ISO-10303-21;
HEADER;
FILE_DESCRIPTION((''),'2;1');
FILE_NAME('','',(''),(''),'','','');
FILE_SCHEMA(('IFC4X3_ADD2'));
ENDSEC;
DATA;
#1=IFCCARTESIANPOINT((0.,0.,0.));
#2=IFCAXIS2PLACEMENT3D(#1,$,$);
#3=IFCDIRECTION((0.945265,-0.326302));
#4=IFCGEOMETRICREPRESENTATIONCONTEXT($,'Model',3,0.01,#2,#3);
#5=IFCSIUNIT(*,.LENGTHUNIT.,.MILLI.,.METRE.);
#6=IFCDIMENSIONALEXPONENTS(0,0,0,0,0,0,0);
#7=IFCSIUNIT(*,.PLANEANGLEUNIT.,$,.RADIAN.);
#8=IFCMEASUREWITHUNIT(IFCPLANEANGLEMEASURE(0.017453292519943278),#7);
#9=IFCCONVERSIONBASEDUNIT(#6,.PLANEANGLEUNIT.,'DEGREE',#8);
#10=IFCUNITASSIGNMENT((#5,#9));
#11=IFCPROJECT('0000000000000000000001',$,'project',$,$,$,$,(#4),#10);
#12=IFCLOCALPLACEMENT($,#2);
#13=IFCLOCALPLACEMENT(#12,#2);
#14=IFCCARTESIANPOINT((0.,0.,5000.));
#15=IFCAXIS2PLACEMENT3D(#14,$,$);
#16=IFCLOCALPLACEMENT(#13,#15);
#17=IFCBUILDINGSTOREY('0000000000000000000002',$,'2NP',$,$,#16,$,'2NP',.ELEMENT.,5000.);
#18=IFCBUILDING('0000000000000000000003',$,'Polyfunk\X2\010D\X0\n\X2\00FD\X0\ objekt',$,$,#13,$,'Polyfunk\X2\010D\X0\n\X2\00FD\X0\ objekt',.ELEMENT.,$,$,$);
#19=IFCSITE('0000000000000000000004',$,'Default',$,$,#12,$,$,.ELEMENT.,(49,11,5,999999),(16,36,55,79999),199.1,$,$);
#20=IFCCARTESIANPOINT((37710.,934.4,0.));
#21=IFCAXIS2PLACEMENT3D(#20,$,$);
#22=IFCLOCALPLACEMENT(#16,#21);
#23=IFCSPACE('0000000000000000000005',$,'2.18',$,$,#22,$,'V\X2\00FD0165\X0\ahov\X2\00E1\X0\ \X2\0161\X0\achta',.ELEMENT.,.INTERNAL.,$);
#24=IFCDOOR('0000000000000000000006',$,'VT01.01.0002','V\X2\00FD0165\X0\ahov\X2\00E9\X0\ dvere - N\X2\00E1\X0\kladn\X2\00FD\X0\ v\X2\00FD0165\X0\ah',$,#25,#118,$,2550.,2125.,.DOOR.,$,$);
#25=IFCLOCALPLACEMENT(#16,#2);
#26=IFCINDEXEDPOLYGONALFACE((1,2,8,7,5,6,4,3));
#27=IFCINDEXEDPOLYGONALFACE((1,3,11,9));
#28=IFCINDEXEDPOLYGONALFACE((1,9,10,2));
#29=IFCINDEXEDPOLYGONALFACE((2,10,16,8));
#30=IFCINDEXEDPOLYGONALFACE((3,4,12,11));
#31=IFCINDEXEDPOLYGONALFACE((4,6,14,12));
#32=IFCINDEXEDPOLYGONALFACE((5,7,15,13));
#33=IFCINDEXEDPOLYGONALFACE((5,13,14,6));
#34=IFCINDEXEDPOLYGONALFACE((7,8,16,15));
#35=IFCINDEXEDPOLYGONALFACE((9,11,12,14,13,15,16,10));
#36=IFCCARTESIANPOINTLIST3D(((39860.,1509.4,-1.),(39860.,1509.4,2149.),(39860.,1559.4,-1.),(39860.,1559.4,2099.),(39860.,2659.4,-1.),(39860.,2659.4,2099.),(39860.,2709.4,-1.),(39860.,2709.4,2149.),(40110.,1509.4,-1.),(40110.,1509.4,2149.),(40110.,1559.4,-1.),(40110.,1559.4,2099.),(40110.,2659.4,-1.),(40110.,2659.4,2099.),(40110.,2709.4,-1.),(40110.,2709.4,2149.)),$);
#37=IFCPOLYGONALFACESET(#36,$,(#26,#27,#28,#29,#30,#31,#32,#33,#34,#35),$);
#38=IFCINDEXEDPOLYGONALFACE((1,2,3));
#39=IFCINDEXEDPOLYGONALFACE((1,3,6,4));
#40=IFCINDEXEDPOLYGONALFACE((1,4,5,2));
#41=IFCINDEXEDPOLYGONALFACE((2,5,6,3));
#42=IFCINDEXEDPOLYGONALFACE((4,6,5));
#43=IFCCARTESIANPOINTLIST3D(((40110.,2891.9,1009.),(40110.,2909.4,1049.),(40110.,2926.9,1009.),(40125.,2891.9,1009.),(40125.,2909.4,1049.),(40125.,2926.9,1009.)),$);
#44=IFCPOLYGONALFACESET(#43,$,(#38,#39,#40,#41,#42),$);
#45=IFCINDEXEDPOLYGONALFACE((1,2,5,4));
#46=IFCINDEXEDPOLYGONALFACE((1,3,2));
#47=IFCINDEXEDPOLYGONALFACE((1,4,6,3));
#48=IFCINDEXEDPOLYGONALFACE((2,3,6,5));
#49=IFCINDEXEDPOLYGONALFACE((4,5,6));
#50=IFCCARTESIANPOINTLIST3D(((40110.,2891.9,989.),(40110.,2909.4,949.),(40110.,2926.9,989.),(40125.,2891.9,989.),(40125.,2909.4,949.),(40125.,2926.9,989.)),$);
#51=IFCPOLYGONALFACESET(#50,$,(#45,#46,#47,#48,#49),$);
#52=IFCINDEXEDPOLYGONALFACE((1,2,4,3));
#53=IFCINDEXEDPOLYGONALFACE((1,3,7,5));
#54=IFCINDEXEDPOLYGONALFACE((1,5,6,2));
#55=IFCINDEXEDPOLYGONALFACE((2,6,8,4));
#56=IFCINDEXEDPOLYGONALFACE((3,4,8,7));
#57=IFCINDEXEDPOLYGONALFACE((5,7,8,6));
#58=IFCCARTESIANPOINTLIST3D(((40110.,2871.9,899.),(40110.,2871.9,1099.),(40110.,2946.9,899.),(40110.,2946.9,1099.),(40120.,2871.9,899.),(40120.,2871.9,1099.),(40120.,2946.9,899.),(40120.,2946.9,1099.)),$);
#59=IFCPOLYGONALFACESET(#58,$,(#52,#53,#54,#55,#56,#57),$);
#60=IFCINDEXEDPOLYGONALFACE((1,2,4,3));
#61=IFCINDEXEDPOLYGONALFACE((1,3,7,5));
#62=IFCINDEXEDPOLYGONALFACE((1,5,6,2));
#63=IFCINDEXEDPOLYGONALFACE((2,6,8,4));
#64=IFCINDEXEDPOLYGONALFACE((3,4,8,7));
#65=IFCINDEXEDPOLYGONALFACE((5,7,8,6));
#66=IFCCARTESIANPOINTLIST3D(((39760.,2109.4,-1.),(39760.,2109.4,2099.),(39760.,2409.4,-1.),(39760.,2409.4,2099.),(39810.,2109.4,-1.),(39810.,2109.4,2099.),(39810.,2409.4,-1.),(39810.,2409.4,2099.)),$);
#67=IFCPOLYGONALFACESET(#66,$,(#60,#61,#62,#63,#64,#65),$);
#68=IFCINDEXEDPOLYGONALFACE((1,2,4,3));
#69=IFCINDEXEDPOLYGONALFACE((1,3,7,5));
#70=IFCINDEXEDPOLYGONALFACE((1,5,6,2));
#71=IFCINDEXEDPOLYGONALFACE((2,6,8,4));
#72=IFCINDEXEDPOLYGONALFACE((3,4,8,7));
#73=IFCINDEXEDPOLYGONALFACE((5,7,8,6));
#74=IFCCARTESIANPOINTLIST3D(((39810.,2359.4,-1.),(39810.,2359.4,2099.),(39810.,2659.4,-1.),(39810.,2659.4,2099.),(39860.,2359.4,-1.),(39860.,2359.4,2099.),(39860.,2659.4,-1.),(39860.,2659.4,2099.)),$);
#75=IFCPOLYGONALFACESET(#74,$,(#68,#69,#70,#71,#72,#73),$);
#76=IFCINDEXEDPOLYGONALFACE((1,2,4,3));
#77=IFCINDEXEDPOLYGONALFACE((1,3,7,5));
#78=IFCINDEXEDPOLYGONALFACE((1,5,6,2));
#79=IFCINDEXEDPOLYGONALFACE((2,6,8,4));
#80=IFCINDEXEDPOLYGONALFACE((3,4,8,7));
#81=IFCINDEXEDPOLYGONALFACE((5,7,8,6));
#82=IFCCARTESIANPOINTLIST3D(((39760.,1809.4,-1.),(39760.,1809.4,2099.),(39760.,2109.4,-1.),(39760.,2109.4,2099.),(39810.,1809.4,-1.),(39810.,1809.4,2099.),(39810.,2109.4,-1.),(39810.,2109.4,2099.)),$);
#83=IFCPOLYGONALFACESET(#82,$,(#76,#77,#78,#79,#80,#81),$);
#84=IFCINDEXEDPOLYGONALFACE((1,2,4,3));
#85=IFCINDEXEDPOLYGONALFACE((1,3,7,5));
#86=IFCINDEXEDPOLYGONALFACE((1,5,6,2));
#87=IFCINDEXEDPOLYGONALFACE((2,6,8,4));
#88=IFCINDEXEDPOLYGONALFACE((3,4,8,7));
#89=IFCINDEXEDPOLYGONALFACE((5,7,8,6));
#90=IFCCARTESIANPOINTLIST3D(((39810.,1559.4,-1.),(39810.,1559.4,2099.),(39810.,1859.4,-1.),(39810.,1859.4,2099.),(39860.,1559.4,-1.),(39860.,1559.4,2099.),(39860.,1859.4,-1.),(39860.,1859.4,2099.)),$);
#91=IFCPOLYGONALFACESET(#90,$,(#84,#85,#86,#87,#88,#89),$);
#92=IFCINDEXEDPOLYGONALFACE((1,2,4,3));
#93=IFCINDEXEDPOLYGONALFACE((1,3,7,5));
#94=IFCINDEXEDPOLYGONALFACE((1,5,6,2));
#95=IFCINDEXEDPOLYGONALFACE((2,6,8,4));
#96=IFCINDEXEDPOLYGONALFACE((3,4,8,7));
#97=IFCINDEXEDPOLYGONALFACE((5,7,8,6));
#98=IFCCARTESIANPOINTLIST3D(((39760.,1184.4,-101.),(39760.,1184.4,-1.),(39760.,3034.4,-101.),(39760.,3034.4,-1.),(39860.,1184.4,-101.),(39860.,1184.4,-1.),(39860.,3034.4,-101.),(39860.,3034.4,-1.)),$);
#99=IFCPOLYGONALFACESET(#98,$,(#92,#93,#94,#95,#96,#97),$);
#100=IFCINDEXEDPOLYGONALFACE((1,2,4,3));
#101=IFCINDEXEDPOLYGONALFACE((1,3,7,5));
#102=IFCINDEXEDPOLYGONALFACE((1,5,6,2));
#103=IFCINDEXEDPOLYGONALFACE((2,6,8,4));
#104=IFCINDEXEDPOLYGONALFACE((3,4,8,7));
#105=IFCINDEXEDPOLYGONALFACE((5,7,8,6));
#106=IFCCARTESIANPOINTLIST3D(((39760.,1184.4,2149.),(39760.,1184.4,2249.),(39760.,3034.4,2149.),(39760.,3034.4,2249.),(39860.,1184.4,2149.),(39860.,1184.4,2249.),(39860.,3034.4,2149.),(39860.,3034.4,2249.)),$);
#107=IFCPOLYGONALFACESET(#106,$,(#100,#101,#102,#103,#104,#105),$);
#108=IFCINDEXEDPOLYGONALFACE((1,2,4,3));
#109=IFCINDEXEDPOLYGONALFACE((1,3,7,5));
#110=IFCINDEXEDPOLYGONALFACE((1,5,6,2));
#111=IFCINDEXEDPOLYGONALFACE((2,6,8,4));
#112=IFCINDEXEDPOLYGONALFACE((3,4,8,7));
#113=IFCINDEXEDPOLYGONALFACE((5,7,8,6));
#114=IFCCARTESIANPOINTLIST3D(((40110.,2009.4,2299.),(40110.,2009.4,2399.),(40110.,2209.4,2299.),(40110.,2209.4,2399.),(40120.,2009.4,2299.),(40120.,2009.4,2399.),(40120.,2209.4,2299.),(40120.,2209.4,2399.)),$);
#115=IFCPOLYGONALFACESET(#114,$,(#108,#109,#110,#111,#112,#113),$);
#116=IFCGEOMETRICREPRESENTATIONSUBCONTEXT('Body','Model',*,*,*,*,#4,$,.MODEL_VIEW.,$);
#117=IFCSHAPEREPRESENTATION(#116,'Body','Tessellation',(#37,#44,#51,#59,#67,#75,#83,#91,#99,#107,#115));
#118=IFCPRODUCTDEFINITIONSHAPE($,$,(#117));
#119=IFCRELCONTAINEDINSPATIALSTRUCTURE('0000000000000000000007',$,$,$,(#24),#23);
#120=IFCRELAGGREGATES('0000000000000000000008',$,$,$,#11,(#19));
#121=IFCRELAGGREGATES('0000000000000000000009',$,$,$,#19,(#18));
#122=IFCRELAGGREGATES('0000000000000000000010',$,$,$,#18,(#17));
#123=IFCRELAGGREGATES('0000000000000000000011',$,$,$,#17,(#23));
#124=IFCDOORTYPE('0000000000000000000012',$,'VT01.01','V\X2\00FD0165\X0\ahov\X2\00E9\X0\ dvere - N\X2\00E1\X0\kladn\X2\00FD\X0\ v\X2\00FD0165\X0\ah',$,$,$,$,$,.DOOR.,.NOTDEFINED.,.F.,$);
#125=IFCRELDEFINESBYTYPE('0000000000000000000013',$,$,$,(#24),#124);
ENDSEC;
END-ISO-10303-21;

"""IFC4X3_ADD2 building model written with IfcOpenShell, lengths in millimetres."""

from ifc_helpers import new_model, entity, si_unit, converted_unit, direction, frame, frame_2d, origin, origin_2d_with_axis, place, context, subcontext, project, spatial, polyline, rectangle, outline, extrude, source, transform, mapped, type_object, type_shapes, element, save


model = new_model("IFC4X3_ADD2")

# Units and contexts
model_context = context("Model", 3, precision=0.01, world=origin(), true_north=direction((0.945265, -0.326302)))
body_context = subcontext(model_context, "Body", "Model", "MODEL_VIEW")
ifc_project = project(units=[si_unit("LENGTHUNIT", "METRE", prefix="MILLI"), converted_unit("PLANEANGLEUNIT", "DEGREE", entity("IfcPlaneAngleMeasure", 0.017453292519943278), si_unit("PLANEANGLEUNIT", "RADIAN"), dimensions=[0, 0, 0, 0, 0, 0, 0])], contexts=[model_context])

# Site, building, storey
site_placement = place(None, origin())
site = spatial("IfcSite", under=ifc_project, at=site_placement, Name="Default", CompositionType="ELEMENT", RefLatitude=(49, 11, 5, 999999), RefLongitude=(16, 36, 55, 79999), RefElevation=199.1)
building_placement = place(site_placement, origin())
building = spatial("IfcBuilding", under=site, at=building_placement, Name="Polyfunkčný objekt", LongName="Polyfunkčný objekt", CompositionType="ELEMENT")
storey_placement = place(building_placement, frame((0.0, 0.0, 5000.0)))
storey = spatial("IfcBuildingStorey", under=building, at=storey_placement, Name="2NP", LongName="2NP", CompositionType="ELEMENT", Elevation=5000.0)

# Shared definitions
space_1_placement = place(storey_placement, frame((37710.0, 934.4, 0.0)))
space_1 = spatial("IfcSpace", under=storey, at=space_1_placement, Name="2.18", LongName="Výťahová šachta", CompositionType="ELEMENT", PredefinedType="INTERNAL")

# Door
door_type_1 = type_object("IfcDoorType", Name="VT01.01", Description="Výťahové dvere - Nákladný výťah", OperationType="NOTDEFINED", ParameterTakesPrecedence=False, PredefinedType="DOOR")
shared_shape_1 = source(origin(), body_context, "Body", "SweptSolid", [
    extrude(outline(polyline([(-1087.5, -600.0), (1062.5, -600.0), (1062.5, -550.0), (-1037.5, -550.0), (-1037.5, 550.0), (1062.5, 550.0), (1062.5, 600.0), (-1087.5, 600.0), (-1087.5, -600.0)])), frame((600.0, 0.0, 1062.5), z_axis=(0.0, 1.0, 0.0), x_axis=(0.0, 0.0, -1.0)), (0.0, 0.0, 1.0), 250.0),
    extrude(outline(polyline([(-24.4, -10.7), (19.2, -10.7), (5.2, 21.4), (-24.4, -10.7)])), frame((1400.0, -15.0, 1023.3), z_axis=(0.0, 1.0, 0.0), x_axis=(0.400819, 0.0, -0.916157)), (0.0, 0.0, 1.0), 15.0),
    extrude(outline(polyline([(-24.4, -10.7), (19.2, -10.7), (5.2, 21.4), (-24.4, -10.7)])), frame((1400.0, -15.0, 976.7), z_axis=(0.0, 1.0, 0.0), x_axis=(-0.400819, 0.0, 0.916157)), (0.0, 0.0, 1.0), 15.0),
    extrude(rectangle(XDim=10.0, YDim=75.0, at=frame_2d((0.0, 0.0), x_axis=(1.0, 0.0))), frame((1400.0, -5.0, 900.0), z_axis=(0.0, 0.0, 1.0), x_axis=(0.0, 1.0, 0.0)), (0.0, 0.0, 1.0), 200.0),
    extrude(rectangle(XDim=50.0, YDim=300.0, at=origin_2d_with_axis()), frame((750.0, 325.0, 0.0), z_axis=(0.0, 0.0, 1.0), x_axis=(0.0, -1.0, 0.0)), (0.0, 0.0, 1.0), 2100.0),
    extrude(rectangle(XDim=50.0, YDim=300.0, at=frame_2d((0.0, 0.0), x_axis=(1.0, 0.0))), frame((1000.0, 275.0, 0.0), z_axis=(0.0, 0.0, 1.0), x_axis=(0.0, -1.0, 0.0)), (0.0, 0.0, 1.0), 2100.0),
    extrude(rectangle(XDim=300.0, YDim=50.0, at=frame_2d((0.0, 0.0), x_axis=(1.0, 0.0))), frame((450.0, 325.0, 0.0), z_axis=(0.0, 0.0, 1.0), x_axis=(-1.0, 0.0, 0.0)), (0.0, 0.0, 1.0), 2100.0),
    extrude(rectangle(XDim=300.0, YDim=50.0, at=frame_2d((0.0, 0.0), x_axis=(1.0, 0.0))), frame((200.0, 275.0, 0.0), z_axis=(0.0, 0.0, 1.0), x_axis=(-1.0, 0.0, 0.0)), (0.0, 0.0, 1.0), 2100.0),
    extrude(rectangle(XDim=1850.0, YDim=100.0, at=frame_2d((0.0, 0.0), x_axis=(1.0, 0.0))), frame((600.0, 300.0, -100.0), z_axis=(0.0, 0.0, 1.0), x_axis=(-1.0, 0.0, 0.0)), (0.0, 0.0, 1.0), 100.0),
    extrude(rectangle(XDim=1850.0, YDim=100.0, at=frame_2d((0.0, 0.0), x_axis=(1.0, 0.0))), frame((600.0, 300.0, 2150.0), z_axis=(0.0, 0.0, 1.0), x_axis=(-1.0, 0.0, 0.0)), (0.0, 0.0, 1.0), 100.0),
    extrude(rectangle(XDim=10.0, YDim=200.0, at=frame_2d((0.0, 0.0), x_axis=(1.0, 0.0))), frame((600.0, -5.0, 2300.0), z_axis=(0.0, 0.0, 1.0), x_axis=(0.0, 1.0, 0.0)), (0.0, 0.0, 1.0), 100.0),
])
type_shapes(door_type_1, [shared_shape_1])
door_1_placement = place(storey_placement, frame((40110.0, 1509.4, -1.0), z_axis=(0.0, 0.0, 1.0), x_axis=(0.0, 1.0, 0.0)))
element("IfcDoor", 1, at=door_1_placement, inside=space_1, type_object=door_type_1, Name="VT01.01.0002", Description="Výťahové dvere - Nákladný výťah", OverallHeight=2550.0, OverallWidth=2125.0, PredefinedType="DOOR", context=body_context, shape_type="MappedRepresentation", body=[
    mapped(shared_shape_1, transform((0.0, 0.0, 0.0), scale=1.0)),
])

save(model, "model.ifc")
